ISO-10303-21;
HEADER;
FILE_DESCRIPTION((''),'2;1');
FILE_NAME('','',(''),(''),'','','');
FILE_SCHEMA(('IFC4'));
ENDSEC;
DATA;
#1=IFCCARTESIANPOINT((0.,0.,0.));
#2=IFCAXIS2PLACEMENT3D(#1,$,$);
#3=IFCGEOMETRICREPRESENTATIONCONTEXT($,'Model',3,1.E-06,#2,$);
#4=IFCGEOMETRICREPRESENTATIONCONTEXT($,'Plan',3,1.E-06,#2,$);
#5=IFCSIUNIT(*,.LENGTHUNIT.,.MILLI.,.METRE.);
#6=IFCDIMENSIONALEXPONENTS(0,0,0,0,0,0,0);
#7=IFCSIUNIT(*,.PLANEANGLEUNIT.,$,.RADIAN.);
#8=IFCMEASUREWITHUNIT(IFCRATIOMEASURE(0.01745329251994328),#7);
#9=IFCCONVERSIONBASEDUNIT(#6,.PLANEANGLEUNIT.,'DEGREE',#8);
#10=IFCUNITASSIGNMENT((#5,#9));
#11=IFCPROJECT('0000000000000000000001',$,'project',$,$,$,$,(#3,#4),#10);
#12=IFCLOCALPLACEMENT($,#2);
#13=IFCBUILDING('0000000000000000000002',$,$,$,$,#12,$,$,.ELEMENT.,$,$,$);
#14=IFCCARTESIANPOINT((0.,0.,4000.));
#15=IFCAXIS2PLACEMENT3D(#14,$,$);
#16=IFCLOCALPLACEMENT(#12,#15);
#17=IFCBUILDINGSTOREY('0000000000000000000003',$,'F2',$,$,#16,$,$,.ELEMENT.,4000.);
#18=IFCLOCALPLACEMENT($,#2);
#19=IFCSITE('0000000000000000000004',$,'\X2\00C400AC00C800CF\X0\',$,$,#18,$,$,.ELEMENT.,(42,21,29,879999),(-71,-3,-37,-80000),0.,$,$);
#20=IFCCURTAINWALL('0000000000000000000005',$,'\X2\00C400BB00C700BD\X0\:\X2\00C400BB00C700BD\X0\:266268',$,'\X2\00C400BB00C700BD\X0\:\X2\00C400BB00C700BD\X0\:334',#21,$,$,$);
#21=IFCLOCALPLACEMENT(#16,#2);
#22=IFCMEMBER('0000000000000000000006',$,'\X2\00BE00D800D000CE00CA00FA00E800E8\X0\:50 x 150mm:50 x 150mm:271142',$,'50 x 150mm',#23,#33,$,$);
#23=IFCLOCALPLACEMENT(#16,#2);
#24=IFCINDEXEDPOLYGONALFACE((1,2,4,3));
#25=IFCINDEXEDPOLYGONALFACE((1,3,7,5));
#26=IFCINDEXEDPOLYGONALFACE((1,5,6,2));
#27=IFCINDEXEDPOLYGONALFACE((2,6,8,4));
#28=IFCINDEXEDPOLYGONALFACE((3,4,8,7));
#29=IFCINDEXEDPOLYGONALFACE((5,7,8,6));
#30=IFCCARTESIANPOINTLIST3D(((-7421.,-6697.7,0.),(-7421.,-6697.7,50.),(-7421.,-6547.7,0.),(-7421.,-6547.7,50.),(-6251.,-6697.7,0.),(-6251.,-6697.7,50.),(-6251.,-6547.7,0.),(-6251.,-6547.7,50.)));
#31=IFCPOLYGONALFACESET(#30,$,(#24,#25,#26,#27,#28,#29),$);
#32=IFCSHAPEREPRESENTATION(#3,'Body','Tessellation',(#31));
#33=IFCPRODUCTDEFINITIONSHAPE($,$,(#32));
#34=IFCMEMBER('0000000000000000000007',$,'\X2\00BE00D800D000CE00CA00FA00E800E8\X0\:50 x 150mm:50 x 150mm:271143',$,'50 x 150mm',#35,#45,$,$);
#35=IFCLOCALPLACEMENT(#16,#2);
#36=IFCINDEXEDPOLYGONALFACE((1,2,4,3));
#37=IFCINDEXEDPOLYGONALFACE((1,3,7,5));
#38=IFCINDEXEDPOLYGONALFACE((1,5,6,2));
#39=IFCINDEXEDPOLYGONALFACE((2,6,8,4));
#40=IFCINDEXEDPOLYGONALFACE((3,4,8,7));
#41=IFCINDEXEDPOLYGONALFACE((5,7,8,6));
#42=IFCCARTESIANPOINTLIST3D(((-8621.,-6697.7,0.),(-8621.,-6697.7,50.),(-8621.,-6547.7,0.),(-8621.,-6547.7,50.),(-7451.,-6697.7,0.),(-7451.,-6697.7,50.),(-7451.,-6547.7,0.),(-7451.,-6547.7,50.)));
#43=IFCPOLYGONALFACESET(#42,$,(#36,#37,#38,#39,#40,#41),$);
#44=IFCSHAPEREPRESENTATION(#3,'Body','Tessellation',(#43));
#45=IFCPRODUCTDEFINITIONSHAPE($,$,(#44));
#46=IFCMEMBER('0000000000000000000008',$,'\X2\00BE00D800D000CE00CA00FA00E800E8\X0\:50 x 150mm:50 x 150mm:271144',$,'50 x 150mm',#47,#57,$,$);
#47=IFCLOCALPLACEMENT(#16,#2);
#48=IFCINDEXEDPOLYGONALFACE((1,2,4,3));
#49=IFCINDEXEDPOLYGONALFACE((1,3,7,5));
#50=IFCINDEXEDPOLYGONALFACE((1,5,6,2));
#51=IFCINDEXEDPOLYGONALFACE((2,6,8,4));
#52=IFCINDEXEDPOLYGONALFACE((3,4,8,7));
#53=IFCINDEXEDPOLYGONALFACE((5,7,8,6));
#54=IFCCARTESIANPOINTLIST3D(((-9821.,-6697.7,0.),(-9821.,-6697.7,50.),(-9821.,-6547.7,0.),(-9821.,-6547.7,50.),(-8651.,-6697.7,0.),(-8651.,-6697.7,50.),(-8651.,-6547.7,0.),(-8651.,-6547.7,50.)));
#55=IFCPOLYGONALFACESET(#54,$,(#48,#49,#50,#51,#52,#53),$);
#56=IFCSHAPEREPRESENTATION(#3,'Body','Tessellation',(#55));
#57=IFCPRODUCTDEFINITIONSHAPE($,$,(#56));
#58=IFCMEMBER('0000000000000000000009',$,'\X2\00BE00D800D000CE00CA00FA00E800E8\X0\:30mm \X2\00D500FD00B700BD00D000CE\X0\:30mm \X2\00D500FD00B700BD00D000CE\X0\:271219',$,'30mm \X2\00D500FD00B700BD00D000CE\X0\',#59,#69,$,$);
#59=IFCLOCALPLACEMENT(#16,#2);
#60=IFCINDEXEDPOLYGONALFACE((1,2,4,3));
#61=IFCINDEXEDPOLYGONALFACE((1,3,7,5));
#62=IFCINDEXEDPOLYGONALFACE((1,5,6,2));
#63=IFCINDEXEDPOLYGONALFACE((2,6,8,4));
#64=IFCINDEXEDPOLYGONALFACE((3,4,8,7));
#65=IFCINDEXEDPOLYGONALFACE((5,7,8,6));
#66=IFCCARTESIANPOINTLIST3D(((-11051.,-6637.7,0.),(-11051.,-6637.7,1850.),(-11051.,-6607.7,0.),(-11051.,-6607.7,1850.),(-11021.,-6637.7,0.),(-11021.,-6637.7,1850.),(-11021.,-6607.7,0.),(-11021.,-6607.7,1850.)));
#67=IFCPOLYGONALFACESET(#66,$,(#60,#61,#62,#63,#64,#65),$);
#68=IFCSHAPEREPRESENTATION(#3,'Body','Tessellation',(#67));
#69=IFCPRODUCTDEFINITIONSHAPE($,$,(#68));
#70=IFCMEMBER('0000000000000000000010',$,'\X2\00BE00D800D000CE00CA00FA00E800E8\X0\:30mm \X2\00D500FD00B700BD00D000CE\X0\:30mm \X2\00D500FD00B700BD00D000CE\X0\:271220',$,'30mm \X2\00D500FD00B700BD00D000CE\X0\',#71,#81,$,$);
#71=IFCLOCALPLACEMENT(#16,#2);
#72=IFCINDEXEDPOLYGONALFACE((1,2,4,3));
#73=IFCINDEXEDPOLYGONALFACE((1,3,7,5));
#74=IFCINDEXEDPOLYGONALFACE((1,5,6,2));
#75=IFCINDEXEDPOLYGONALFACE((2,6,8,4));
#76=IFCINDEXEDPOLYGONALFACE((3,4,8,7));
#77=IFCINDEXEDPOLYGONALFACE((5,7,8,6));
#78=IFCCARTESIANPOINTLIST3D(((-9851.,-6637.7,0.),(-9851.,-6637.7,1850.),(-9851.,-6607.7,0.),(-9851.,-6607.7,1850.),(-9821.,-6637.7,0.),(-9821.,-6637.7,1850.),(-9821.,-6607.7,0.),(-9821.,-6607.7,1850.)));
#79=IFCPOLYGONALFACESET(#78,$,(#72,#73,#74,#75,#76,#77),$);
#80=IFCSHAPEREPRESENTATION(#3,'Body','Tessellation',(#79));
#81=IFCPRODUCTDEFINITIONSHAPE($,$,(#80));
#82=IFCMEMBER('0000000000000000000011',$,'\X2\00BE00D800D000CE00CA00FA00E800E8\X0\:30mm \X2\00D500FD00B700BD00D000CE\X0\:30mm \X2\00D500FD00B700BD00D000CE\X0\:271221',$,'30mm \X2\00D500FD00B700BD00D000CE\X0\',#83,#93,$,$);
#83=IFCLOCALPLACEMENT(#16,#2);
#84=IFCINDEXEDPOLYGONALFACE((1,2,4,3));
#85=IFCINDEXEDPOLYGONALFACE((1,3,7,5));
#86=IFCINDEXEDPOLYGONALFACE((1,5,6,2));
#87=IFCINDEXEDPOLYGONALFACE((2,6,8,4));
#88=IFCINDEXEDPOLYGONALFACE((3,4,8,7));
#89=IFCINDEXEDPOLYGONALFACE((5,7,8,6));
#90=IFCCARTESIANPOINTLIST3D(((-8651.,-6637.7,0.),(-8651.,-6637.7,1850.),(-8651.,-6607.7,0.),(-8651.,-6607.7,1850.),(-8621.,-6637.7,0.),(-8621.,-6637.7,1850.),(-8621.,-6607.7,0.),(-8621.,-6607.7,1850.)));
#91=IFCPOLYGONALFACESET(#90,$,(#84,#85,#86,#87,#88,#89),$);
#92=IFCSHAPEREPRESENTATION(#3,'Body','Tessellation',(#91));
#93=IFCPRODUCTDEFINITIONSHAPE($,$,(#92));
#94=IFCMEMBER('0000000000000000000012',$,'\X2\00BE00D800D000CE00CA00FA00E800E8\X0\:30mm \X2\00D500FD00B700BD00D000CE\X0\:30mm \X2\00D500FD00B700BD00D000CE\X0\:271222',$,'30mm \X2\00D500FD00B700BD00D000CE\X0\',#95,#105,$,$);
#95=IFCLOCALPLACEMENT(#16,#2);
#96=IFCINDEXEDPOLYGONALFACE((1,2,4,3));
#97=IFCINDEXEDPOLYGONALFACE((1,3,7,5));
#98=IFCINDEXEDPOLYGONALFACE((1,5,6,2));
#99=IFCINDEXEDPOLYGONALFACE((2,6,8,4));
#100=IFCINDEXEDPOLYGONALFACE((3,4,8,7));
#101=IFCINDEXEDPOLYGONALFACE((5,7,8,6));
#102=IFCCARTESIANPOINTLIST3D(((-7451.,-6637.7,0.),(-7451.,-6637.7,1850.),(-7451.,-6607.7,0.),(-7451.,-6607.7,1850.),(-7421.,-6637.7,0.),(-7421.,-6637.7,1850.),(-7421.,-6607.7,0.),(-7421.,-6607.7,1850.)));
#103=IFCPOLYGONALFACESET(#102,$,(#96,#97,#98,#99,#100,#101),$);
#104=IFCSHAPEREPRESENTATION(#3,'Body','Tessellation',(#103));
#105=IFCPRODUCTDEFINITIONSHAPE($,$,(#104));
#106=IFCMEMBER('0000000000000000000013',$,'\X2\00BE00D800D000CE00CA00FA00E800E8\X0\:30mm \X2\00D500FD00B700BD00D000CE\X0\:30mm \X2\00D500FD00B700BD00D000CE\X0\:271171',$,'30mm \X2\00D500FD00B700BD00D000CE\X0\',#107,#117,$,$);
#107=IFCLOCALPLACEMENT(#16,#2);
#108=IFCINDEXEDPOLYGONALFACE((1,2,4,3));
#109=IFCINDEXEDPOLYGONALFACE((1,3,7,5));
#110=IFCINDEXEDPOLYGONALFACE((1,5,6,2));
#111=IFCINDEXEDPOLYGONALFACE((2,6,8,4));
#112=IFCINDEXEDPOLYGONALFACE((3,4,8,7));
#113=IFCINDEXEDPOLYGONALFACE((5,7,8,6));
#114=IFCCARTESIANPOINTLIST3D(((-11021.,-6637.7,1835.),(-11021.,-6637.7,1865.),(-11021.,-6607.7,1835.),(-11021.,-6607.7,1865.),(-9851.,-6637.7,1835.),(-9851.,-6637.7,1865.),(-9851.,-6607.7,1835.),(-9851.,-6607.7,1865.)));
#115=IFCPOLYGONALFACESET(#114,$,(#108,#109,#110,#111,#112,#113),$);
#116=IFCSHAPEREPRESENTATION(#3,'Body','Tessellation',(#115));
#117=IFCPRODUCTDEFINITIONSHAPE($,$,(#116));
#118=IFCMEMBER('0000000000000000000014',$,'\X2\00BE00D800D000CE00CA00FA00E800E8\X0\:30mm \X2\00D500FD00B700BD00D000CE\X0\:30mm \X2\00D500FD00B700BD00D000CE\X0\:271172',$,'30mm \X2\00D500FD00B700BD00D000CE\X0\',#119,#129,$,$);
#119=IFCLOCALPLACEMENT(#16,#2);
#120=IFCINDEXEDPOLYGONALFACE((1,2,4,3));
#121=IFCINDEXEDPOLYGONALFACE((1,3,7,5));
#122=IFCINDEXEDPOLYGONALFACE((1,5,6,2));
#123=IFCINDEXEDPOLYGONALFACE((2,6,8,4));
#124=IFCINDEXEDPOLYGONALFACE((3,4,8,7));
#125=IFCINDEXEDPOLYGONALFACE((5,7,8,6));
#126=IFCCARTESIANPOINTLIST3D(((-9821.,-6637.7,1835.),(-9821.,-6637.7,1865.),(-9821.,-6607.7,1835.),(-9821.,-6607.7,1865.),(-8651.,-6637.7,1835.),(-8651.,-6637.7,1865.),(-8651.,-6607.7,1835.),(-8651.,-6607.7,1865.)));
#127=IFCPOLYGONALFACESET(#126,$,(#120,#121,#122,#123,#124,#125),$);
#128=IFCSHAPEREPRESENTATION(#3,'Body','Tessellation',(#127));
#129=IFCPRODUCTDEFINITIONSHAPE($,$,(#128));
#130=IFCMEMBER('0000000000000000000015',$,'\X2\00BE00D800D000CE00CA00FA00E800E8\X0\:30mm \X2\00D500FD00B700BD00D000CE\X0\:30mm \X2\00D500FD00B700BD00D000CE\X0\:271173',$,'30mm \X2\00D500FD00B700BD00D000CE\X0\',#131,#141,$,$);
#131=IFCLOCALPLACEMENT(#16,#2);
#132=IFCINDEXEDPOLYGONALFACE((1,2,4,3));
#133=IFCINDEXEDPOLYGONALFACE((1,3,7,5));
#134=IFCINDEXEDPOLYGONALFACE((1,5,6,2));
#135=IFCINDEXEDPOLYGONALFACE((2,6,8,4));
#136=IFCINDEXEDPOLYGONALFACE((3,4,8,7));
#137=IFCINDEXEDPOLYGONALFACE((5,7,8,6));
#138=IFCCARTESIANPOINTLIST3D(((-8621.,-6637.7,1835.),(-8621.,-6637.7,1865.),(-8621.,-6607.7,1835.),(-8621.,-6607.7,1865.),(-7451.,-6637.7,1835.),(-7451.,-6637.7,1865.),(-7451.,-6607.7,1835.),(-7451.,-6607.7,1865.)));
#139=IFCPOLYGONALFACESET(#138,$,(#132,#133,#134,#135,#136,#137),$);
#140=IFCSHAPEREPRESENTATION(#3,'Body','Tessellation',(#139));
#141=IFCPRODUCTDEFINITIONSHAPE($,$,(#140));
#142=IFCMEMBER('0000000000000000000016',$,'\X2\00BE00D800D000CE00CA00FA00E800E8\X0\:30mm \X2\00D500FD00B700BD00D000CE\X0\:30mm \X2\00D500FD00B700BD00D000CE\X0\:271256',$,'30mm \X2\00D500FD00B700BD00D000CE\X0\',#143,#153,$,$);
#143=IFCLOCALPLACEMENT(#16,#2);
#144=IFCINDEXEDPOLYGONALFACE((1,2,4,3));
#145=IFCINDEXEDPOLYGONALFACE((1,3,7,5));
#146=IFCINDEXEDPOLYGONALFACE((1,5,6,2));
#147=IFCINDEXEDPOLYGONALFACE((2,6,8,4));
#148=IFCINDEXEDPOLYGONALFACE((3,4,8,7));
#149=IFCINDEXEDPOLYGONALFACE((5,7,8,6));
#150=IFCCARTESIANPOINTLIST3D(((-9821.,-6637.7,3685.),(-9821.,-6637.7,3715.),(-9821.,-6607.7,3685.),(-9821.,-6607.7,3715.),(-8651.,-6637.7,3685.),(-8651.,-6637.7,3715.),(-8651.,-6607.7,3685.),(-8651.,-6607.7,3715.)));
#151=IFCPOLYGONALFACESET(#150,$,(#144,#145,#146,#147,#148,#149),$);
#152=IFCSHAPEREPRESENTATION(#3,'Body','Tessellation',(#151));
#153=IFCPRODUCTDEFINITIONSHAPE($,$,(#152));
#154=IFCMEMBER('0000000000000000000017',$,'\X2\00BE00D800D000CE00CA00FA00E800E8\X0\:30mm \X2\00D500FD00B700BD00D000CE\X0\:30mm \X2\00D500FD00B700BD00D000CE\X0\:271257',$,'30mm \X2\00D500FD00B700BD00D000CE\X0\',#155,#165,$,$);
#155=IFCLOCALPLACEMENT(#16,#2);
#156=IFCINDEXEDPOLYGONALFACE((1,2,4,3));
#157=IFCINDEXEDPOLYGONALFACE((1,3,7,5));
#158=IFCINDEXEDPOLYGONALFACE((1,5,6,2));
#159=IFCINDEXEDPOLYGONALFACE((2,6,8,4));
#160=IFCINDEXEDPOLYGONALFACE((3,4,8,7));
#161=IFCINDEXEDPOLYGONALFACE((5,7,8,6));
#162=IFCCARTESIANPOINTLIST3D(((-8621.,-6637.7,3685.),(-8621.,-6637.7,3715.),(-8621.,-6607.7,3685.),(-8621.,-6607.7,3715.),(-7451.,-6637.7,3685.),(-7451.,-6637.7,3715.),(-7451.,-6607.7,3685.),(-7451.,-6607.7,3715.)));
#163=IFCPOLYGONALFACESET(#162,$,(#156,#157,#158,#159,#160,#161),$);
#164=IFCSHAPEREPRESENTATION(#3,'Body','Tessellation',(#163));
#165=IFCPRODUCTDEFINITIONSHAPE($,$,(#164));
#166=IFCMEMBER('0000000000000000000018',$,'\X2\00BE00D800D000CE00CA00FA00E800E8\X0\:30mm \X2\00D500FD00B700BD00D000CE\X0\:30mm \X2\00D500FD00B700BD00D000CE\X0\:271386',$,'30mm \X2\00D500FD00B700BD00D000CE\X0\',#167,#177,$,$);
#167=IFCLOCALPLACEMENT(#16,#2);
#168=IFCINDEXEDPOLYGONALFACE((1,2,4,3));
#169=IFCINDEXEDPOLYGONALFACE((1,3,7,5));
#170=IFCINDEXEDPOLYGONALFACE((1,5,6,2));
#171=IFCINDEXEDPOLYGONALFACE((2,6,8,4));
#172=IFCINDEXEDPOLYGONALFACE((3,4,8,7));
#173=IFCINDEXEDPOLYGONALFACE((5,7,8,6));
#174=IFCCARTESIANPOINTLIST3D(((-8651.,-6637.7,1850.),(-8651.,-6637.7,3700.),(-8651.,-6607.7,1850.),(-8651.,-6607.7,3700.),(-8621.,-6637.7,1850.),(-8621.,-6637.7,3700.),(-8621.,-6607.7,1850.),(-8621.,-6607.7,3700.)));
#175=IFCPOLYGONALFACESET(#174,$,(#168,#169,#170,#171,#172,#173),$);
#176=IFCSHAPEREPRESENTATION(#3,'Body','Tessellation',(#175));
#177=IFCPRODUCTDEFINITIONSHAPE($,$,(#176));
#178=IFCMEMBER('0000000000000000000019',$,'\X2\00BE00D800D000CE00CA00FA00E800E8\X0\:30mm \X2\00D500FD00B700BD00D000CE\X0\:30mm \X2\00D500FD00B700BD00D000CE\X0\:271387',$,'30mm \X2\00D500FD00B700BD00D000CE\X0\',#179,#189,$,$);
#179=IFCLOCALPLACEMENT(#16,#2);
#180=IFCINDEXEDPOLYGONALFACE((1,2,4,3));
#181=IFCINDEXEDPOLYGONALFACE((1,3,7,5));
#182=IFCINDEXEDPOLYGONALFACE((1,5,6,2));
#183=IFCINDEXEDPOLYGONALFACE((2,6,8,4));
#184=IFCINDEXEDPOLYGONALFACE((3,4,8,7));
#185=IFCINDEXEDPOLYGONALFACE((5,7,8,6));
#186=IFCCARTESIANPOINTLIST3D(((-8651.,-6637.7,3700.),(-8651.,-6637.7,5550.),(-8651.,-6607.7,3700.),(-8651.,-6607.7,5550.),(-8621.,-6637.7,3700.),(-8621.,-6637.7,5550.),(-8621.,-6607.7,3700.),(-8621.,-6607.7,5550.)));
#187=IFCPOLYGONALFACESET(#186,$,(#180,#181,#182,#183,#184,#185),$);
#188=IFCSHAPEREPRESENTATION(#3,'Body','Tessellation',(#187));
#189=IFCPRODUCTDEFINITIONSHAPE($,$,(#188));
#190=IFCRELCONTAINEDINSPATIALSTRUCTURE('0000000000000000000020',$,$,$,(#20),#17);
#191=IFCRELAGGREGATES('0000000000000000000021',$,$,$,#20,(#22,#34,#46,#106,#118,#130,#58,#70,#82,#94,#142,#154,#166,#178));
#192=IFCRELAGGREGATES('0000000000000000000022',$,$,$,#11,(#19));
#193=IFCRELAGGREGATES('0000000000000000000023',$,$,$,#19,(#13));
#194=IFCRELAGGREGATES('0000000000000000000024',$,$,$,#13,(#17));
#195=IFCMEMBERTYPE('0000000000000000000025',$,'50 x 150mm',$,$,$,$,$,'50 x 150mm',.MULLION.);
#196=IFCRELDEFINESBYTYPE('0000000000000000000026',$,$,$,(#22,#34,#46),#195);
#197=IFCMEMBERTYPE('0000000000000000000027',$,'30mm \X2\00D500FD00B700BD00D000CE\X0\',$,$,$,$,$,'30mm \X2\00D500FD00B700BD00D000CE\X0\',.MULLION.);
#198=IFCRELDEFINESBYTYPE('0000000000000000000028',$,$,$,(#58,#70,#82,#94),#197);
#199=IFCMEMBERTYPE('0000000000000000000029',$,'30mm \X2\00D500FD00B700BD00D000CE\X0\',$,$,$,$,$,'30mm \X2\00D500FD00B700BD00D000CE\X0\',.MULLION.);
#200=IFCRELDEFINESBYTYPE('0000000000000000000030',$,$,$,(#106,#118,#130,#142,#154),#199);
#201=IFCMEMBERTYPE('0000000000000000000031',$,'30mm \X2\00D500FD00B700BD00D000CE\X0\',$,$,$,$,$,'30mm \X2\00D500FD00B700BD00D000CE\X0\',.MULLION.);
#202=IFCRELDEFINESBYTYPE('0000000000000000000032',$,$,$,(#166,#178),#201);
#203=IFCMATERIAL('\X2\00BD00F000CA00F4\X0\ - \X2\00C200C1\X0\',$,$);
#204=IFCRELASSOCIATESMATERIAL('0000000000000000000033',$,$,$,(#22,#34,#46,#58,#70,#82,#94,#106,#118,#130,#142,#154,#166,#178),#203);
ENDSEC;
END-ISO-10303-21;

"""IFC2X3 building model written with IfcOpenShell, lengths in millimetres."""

from ifc_helpers import new_model, entity, si_unit, converted_unit, frame, origin, origin_2d_with_axis, place, context, project, spatial, rectangle, extrude, source, transform, mapped, material, type_object, type_shapes, element, aggregate, save


model = new_model("IFC2X3")

# Units and contexts
model_context = context("Model", 3, precision=1e-06, world=origin())
plan_context = context("Plan", 3, precision=1e-06, world=origin())
ifc_project = project(units=[si_unit("LENGTHUNIT", "METRE", prefix="MILLI"), converted_unit("PLANEANGLEUNIT", "DEGREE", entity("IfcRatioMeasure", 0.01745329251994328), si_unit("PLANEANGLEUNIT", "RADIAN"), dimensions=[0, 0, 0, 0, 0, 0, 0])], contexts=[model_context, plan_context])

# Site, building, storey
site_placement = place(None, origin())
site = spatial("IfcSite", under=ifc_project, at=site_placement, Name="Ä¬ÈÏ", CompositionType="ELEMENT", RefLatitude=(42, 21, 29, 879999), RefLongitude=(-71, -3, -37, -80000), RefElevation=0.0)
building_placement = place(None, origin())
building = spatial("IfcBuilding", under=site, at=building_placement, CompositionType="ELEMENT")
storey_placement = place(building_placement, frame((0.0, 0.0, 4000.0)))
storey = spatial("IfcBuildingStorey", under=building, at=storey_placement, Name="F2", CompositionType="ELEMENT", Elevation=4000.0)

# Curtain wall, members
curtain_wall_placement = place(storey_placement, origin())
curtain_wall = element("IfcCurtainWall", 1, at=curtain_wall_placement, inside=storey, Name="Ä»Ç½:Ä»Ç½:266268", ObjectType="Ä»Ç½:Ä»Ç½:334")
ifc_material_1 = material(Name="½ðÊô - ÂÁ")
member_type_1 = type_object("IfcMemberType", Name="50 x 150mm", ElementType="50 x 150mm", PredefinedType="MULLION")
shared_shape_1 = source(origin(), model_context, "Body", "SweptSolid", [
    extrude(rectangle(XDim=50.0, YDim=150.0, at=origin_2d_with_axis()), frame((-25.0, 0.0, -1170.0), z_axis=(0.0, 0.0, 1.0), x_axis=(-1.0, 0.0, 0.0)), (0.0, 0.0, 1.0), 1170.0),
])
type_shapes(member_type_1, [shared_shape_1])
member_1_placement = place(storey_placement, frame((-7421.0, -6622.7, 0.0), z_axis=(-1.0, 0.0, 0.0), x_axis=(0.0, 0.0, -1.0)))
member_1 = element("IfcMember", 2, at=member_1_placement, type_object=member_type_1, material=ifc_material_1, Name="¾ØÐÎÊúèè:50 x 150mm:50 x 150mm:271142", ObjectType="50 x 150mm", context=model_context, shape_type="MappedRepresentation", body=[
    mapped(shared_shape_1, transform((0.0, 0.0, 0.0), scale=1.0)),
])
member_2_placement = place(storey_placement, frame((-8621.0, -6622.7, 0.0), z_axis=(-1.0, 0.0, 0.0), x_axis=(0.0, 0.0, -1.0)))
member_2 = element("IfcMember", 3, at=member_2_placement, type_object=member_type_1, material=ifc_material_1, Name="¾ØÐÎÊúèè:50 x 150mm:50 x 150mm:271143", ObjectType="50 x 150mm", context=model_context, shape_type="MappedRepresentation", body=[
    mapped(shared_shape_1, transform((0.0, 0.0, 0.0), scale=1.0)),
])
member_3_placement = place(storey_placement, frame((-9821.0, -6622.7, 0.0), z_axis=(-1.0, 0.0, 0.0), x_axis=(0.0, 0.0, -1.0)))
member_3 = element("IfcMember", 4, at=member_3_placement, type_object=member_type_1, material=ifc_material_1, Name="¾ØÐÎÊúèè:50 x 150mm:50 x 150mm:271144", ObjectType="50 x 150mm", context=model_context, shape_type="MappedRepresentation", body=[
    mapped(shared_shape_1, transform((0.0, 0.0, 0.0), scale=1.0)),
])
member_type_2 = type_object("IfcMemberType", Name="30mm Õý·½ÐÎ", ElementType="30mm Õý·½ÐÎ", PredefinedType="MULLION")
shared_shape_2 = source(origin(), model_context, "Body", "SweptSolid", [
    extrude(rectangle(XDim=30.0, YDim=30.0, at=origin_2d_with_axis()), frame((0.0, 0.0, -1850.0), z_axis=(0.0, 0.0, 1.0), x_axis=(-1.0, 0.0, 0.0)), (0.0, 0.0, 1.0), 1850.0),
])
type_shapes(member_type_2, [shared_shape_2])
member_4_placement = place(storey_placement, frame((-11036.0, -6622.7, 0.0), z_axis=(0.0, 0.0, -1.0), x_axis=(1.0, 0.0, 0.0)))
member_4 = element("IfcMember", 5, at=member_4_placement, type_object=member_type_2, material=ifc_material_1, Name="¾ØÐÎÊúèè:30mm Õý·½ÐÎ:30mm Õý·½ÐÎ:271219", ObjectType="30mm Õý·½ÐÎ", context=model_context, shape_type="MappedRepresentation", body=[
    mapped(shared_shape_2, transform((0.0, 0.0, 0.0), scale=1.0)),
])
member_5_placement = place(storey_placement, frame((-9836.0, -6622.7, 0.0), z_axis=(0.0, 0.0, -1.0), x_axis=(1.0, 0.0, 0.0)))
member_5 = element("IfcMember", 6, at=member_5_placement, type_object=member_type_2, material=ifc_material_1, Name="¾ØÐÎÊúèè:30mm Õý·½ÐÎ:30mm Õý·½ÐÎ:271220", ObjectType="30mm Õý·½ÐÎ", context=model_context, shape_type="MappedRepresentation", body=[
    mapped(shared_shape_2, transform((0.0, 0.0, 0.0), scale=1.0)),
])
member_6_placement = place(storey_placement, frame((-8636.0, -6622.7, 0.0), z_axis=(0.0, 0.0, -1.0), x_axis=(1.0, 0.0, 0.0)))
member_6 = element("IfcMember", 7, at=member_6_placement, type_object=member_type_2, material=ifc_material_1, Name="¾ØÐÎÊúèè:30mm Õý·½ÐÎ:30mm Õý·½ÐÎ:271221", ObjectType="30mm Õý·½ÐÎ", context=model_context, shape_type="MappedRepresentation", body=[
    mapped(shared_shape_2, transform((0.0, 0.0, 0.0), scale=1.0)),
])
member_7_placement = place(storey_placement, frame((-7436.0, -6622.7, 0.0), z_axis=(0.0, 0.0, -1.0), x_axis=(1.0, 0.0, 0.0)))
member_7 = element("IfcMember", 8, at=member_7_placement, type_object=member_type_2, material=ifc_material_1, Name="¾ØÐÎÊúèè:30mm Õý·½ÐÎ:30mm Õý·½ÐÎ:271222", ObjectType="30mm Õý·½ÐÎ", context=model_context, shape_type="MappedRepresentation", body=[
    mapped(shared_shape_2, transform((0.0, 0.0, 0.0), scale=1.0)),
])
member_type_3 = type_object("IfcMemberType", Name="30mm Õý·½ÐÎ", ElementType="30mm Õý·½ÐÎ", PredefinedType="MULLION")
shared_shape_3 = source(origin(), model_context, "Body", "SweptSolid", [
    extrude(rectangle(XDim=30.0, YDim=30.0, at=origin_2d_with_axis()), frame((0.0, 0.0, -1170.0), z_axis=(0.0, 0.0, 1.0), x_axis=(-1.0, 0.0, 0.0)), (0.0, 0.0, 1.0), 1170.0),
])
type_shapes(member_type_3, [shared_shape_3])
member_8_placement = place(storey_placement, frame((-9851.0, -6622.7, 1850.0), z_axis=(1.0, 0.0, 0.0), x_axis=(0.0, 0.0, 1.0)))
member_8 = element("IfcMember", 9, at=member_8_placement, type_object=member_type_3, material=ifc_material_1, Name="¾ØÐÎÊúèè:30mm Õý·½ÐÎ:30mm Õý·½ÐÎ:271171", ObjectType="30mm Õý·½ÐÎ", context=model_context, shape_type="MappedRepresentation", body=[
    mapped(shared_shape_3, transform((0.0, 0.0, 0.0), scale=1.0)),
])
member_9_placement = place(storey_placement, frame((-8651.0, -6622.7, 1850.0), z_axis=(1.0, 0.0, 0.0), x_axis=(0.0, 0.0, 1.0)))
member_9 = element("IfcMember", 10, at=member_9_placement, type_object=member_type_3, material=ifc_material_1, Name="¾ØÐÎÊúèè:30mm Õý·½ÐÎ:30mm Õý·½ÐÎ:271172", ObjectType="30mm Õý·½ÐÎ", context=model_context, shape_type="MappedRepresentation", body=[
    mapped(shared_shape_3, transform((0.0, 0.0, 0.0), scale=1.0)),
])
member_10_placement = place(storey_placement, frame((-7451.0, -6622.7, 1850.0), z_axis=(1.0, 0.0, 0.0), x_axis=(0.0, 0.0, 1.0)))
member_10 = element("IfcMember", 11, at=member_10_placement, type_object=member_type_3, material=ifc_material_1, Name="¾ØÐÎÊúèè:30mm Õý·½ÐÎ:30mm Õý·½ÐÎ:271173", ObjectType="30mm Õý·½ÐÎ", context=model_context, shape_type="MappedRepresentation", body=[
    mapped(shared_shape_3, transform((0.0, 0.0, 0.0), scale=1.0)),
])
placement = place(building_placement, frame((0.0, 0.0, 7700.0)))
member_11_placement = place(placement, frame((-8651.0, -6622.7, 0.0), z_axis=(1.0, 0.0, 0.0), x_axis=(0.0, 0.0, 1.0)))
member_11 = element("IfcMember", 12, at=member_11_placement, type_object=member_type_3, material=ifc_material_1, Name="¾ØÐÎÊúèè:30mm Õý·½ÐÎ:30mm Õý·½ÐÎ:271256", ObjectType="30mm Õý·½ÐÎ", context=model_context, shape_type="MappedRepresentation", body=[
    mapped(shared_shape_3, transform((0.0, 0.0, 0.0), scale=1.0)),
])
member_12_placement = place(placement, frame((-7451.0, -6622.7, 0.0), z_axis=(1.0, 0.0, 0.0), x_axis=(0.0, 0.0, 1.0)))
member_12 = element("IfcMember", 13, at=member_12_placement, type_object=member_type_3, material=ifc_material_1, Name="¾ØÐÎÊúèè:30mm Õý·½ÐÎ:30mm Õý·½ÐÎ:271257", ObjectType="30mm Õý·½ÐÎ", context=model_context, shape_type="MappedRepresentation", body=[
    mapped(shared_shape_3, transform((0.0, 0.0, 0.0), scale=1.0)),
])
member_type_4 = type_object("IfcMemberType", Name="30mm Õý·½ÐÎ", ElementType="30mm Õý·½ÐÎ", PredefinedType="MULLION")
shared_shape_4 = source(origin(), model_context, "Body", "SweptSolid", [
    extrude(rectangle(XDim=30.0, YDim=30.0, at=origin_2d_with_axis()), frame((0.0, 0.0, -1850.0), z_axis=(0.0, 0.0, 1.0), x_axis=(-1.0, 0.0, 0.0)), (0.0, 0.0, 1.0), 1850.0),
])
type_shapes(member_type_4, [shared_shape_4])
member_13_placement = place(storey_placement, frame((-8636.0, -6622.7, 1850.0), z_axis=(0.0, 0.0, -1.0), x_axis=(1.0, 0.0, 0.0)))
member_13 = element("IfcMember", 14, at=member_13_placement, type_object=member_type_4, material=ifc_material_1, Name="¾ØÐÎÊúèè:30mm Õý·½ÐÎ:30mm Õý·½ÐÎ:271386", ObjectType="30mm Õý·½ÐÎ", context=model_context, shape_type="MappedRepresentation", body=[
    mapped(shared_shape_4, transform((0.0, 0.0, 0.0), scale=1.0)),
])
member_14_placement = place(placement, frame((-8636.0, -6622.7, 0.0), z_axis=(0.0, 0.0, -1.0), x_axis=(1.0, 0.0, 0.0)))
member_14 = element("IfcMember", 15, at=member_14_placement, type_object=member_type_4, material=ifc_material_1, Name="¾ØÐÎÊúèè:30mm Õý·½ÐÎ:30mm Õý·½ÐÎ:271387", ObjectType="30mm Õý·½ÐÎ", context=model_context, shape_type="MappedRepresentation", body=[
    mapped(shared_shape_4, transform((0.0, 0.0, 0.0), scale=1.0)),
])
aggregate(curtain_wall, [member_1, member_2, member_3, member_8, member_9, member_10, member_4, member_5, member_6, member_7, member_11, member_12, member_13, member_14])

save(model, "model.ifc")
